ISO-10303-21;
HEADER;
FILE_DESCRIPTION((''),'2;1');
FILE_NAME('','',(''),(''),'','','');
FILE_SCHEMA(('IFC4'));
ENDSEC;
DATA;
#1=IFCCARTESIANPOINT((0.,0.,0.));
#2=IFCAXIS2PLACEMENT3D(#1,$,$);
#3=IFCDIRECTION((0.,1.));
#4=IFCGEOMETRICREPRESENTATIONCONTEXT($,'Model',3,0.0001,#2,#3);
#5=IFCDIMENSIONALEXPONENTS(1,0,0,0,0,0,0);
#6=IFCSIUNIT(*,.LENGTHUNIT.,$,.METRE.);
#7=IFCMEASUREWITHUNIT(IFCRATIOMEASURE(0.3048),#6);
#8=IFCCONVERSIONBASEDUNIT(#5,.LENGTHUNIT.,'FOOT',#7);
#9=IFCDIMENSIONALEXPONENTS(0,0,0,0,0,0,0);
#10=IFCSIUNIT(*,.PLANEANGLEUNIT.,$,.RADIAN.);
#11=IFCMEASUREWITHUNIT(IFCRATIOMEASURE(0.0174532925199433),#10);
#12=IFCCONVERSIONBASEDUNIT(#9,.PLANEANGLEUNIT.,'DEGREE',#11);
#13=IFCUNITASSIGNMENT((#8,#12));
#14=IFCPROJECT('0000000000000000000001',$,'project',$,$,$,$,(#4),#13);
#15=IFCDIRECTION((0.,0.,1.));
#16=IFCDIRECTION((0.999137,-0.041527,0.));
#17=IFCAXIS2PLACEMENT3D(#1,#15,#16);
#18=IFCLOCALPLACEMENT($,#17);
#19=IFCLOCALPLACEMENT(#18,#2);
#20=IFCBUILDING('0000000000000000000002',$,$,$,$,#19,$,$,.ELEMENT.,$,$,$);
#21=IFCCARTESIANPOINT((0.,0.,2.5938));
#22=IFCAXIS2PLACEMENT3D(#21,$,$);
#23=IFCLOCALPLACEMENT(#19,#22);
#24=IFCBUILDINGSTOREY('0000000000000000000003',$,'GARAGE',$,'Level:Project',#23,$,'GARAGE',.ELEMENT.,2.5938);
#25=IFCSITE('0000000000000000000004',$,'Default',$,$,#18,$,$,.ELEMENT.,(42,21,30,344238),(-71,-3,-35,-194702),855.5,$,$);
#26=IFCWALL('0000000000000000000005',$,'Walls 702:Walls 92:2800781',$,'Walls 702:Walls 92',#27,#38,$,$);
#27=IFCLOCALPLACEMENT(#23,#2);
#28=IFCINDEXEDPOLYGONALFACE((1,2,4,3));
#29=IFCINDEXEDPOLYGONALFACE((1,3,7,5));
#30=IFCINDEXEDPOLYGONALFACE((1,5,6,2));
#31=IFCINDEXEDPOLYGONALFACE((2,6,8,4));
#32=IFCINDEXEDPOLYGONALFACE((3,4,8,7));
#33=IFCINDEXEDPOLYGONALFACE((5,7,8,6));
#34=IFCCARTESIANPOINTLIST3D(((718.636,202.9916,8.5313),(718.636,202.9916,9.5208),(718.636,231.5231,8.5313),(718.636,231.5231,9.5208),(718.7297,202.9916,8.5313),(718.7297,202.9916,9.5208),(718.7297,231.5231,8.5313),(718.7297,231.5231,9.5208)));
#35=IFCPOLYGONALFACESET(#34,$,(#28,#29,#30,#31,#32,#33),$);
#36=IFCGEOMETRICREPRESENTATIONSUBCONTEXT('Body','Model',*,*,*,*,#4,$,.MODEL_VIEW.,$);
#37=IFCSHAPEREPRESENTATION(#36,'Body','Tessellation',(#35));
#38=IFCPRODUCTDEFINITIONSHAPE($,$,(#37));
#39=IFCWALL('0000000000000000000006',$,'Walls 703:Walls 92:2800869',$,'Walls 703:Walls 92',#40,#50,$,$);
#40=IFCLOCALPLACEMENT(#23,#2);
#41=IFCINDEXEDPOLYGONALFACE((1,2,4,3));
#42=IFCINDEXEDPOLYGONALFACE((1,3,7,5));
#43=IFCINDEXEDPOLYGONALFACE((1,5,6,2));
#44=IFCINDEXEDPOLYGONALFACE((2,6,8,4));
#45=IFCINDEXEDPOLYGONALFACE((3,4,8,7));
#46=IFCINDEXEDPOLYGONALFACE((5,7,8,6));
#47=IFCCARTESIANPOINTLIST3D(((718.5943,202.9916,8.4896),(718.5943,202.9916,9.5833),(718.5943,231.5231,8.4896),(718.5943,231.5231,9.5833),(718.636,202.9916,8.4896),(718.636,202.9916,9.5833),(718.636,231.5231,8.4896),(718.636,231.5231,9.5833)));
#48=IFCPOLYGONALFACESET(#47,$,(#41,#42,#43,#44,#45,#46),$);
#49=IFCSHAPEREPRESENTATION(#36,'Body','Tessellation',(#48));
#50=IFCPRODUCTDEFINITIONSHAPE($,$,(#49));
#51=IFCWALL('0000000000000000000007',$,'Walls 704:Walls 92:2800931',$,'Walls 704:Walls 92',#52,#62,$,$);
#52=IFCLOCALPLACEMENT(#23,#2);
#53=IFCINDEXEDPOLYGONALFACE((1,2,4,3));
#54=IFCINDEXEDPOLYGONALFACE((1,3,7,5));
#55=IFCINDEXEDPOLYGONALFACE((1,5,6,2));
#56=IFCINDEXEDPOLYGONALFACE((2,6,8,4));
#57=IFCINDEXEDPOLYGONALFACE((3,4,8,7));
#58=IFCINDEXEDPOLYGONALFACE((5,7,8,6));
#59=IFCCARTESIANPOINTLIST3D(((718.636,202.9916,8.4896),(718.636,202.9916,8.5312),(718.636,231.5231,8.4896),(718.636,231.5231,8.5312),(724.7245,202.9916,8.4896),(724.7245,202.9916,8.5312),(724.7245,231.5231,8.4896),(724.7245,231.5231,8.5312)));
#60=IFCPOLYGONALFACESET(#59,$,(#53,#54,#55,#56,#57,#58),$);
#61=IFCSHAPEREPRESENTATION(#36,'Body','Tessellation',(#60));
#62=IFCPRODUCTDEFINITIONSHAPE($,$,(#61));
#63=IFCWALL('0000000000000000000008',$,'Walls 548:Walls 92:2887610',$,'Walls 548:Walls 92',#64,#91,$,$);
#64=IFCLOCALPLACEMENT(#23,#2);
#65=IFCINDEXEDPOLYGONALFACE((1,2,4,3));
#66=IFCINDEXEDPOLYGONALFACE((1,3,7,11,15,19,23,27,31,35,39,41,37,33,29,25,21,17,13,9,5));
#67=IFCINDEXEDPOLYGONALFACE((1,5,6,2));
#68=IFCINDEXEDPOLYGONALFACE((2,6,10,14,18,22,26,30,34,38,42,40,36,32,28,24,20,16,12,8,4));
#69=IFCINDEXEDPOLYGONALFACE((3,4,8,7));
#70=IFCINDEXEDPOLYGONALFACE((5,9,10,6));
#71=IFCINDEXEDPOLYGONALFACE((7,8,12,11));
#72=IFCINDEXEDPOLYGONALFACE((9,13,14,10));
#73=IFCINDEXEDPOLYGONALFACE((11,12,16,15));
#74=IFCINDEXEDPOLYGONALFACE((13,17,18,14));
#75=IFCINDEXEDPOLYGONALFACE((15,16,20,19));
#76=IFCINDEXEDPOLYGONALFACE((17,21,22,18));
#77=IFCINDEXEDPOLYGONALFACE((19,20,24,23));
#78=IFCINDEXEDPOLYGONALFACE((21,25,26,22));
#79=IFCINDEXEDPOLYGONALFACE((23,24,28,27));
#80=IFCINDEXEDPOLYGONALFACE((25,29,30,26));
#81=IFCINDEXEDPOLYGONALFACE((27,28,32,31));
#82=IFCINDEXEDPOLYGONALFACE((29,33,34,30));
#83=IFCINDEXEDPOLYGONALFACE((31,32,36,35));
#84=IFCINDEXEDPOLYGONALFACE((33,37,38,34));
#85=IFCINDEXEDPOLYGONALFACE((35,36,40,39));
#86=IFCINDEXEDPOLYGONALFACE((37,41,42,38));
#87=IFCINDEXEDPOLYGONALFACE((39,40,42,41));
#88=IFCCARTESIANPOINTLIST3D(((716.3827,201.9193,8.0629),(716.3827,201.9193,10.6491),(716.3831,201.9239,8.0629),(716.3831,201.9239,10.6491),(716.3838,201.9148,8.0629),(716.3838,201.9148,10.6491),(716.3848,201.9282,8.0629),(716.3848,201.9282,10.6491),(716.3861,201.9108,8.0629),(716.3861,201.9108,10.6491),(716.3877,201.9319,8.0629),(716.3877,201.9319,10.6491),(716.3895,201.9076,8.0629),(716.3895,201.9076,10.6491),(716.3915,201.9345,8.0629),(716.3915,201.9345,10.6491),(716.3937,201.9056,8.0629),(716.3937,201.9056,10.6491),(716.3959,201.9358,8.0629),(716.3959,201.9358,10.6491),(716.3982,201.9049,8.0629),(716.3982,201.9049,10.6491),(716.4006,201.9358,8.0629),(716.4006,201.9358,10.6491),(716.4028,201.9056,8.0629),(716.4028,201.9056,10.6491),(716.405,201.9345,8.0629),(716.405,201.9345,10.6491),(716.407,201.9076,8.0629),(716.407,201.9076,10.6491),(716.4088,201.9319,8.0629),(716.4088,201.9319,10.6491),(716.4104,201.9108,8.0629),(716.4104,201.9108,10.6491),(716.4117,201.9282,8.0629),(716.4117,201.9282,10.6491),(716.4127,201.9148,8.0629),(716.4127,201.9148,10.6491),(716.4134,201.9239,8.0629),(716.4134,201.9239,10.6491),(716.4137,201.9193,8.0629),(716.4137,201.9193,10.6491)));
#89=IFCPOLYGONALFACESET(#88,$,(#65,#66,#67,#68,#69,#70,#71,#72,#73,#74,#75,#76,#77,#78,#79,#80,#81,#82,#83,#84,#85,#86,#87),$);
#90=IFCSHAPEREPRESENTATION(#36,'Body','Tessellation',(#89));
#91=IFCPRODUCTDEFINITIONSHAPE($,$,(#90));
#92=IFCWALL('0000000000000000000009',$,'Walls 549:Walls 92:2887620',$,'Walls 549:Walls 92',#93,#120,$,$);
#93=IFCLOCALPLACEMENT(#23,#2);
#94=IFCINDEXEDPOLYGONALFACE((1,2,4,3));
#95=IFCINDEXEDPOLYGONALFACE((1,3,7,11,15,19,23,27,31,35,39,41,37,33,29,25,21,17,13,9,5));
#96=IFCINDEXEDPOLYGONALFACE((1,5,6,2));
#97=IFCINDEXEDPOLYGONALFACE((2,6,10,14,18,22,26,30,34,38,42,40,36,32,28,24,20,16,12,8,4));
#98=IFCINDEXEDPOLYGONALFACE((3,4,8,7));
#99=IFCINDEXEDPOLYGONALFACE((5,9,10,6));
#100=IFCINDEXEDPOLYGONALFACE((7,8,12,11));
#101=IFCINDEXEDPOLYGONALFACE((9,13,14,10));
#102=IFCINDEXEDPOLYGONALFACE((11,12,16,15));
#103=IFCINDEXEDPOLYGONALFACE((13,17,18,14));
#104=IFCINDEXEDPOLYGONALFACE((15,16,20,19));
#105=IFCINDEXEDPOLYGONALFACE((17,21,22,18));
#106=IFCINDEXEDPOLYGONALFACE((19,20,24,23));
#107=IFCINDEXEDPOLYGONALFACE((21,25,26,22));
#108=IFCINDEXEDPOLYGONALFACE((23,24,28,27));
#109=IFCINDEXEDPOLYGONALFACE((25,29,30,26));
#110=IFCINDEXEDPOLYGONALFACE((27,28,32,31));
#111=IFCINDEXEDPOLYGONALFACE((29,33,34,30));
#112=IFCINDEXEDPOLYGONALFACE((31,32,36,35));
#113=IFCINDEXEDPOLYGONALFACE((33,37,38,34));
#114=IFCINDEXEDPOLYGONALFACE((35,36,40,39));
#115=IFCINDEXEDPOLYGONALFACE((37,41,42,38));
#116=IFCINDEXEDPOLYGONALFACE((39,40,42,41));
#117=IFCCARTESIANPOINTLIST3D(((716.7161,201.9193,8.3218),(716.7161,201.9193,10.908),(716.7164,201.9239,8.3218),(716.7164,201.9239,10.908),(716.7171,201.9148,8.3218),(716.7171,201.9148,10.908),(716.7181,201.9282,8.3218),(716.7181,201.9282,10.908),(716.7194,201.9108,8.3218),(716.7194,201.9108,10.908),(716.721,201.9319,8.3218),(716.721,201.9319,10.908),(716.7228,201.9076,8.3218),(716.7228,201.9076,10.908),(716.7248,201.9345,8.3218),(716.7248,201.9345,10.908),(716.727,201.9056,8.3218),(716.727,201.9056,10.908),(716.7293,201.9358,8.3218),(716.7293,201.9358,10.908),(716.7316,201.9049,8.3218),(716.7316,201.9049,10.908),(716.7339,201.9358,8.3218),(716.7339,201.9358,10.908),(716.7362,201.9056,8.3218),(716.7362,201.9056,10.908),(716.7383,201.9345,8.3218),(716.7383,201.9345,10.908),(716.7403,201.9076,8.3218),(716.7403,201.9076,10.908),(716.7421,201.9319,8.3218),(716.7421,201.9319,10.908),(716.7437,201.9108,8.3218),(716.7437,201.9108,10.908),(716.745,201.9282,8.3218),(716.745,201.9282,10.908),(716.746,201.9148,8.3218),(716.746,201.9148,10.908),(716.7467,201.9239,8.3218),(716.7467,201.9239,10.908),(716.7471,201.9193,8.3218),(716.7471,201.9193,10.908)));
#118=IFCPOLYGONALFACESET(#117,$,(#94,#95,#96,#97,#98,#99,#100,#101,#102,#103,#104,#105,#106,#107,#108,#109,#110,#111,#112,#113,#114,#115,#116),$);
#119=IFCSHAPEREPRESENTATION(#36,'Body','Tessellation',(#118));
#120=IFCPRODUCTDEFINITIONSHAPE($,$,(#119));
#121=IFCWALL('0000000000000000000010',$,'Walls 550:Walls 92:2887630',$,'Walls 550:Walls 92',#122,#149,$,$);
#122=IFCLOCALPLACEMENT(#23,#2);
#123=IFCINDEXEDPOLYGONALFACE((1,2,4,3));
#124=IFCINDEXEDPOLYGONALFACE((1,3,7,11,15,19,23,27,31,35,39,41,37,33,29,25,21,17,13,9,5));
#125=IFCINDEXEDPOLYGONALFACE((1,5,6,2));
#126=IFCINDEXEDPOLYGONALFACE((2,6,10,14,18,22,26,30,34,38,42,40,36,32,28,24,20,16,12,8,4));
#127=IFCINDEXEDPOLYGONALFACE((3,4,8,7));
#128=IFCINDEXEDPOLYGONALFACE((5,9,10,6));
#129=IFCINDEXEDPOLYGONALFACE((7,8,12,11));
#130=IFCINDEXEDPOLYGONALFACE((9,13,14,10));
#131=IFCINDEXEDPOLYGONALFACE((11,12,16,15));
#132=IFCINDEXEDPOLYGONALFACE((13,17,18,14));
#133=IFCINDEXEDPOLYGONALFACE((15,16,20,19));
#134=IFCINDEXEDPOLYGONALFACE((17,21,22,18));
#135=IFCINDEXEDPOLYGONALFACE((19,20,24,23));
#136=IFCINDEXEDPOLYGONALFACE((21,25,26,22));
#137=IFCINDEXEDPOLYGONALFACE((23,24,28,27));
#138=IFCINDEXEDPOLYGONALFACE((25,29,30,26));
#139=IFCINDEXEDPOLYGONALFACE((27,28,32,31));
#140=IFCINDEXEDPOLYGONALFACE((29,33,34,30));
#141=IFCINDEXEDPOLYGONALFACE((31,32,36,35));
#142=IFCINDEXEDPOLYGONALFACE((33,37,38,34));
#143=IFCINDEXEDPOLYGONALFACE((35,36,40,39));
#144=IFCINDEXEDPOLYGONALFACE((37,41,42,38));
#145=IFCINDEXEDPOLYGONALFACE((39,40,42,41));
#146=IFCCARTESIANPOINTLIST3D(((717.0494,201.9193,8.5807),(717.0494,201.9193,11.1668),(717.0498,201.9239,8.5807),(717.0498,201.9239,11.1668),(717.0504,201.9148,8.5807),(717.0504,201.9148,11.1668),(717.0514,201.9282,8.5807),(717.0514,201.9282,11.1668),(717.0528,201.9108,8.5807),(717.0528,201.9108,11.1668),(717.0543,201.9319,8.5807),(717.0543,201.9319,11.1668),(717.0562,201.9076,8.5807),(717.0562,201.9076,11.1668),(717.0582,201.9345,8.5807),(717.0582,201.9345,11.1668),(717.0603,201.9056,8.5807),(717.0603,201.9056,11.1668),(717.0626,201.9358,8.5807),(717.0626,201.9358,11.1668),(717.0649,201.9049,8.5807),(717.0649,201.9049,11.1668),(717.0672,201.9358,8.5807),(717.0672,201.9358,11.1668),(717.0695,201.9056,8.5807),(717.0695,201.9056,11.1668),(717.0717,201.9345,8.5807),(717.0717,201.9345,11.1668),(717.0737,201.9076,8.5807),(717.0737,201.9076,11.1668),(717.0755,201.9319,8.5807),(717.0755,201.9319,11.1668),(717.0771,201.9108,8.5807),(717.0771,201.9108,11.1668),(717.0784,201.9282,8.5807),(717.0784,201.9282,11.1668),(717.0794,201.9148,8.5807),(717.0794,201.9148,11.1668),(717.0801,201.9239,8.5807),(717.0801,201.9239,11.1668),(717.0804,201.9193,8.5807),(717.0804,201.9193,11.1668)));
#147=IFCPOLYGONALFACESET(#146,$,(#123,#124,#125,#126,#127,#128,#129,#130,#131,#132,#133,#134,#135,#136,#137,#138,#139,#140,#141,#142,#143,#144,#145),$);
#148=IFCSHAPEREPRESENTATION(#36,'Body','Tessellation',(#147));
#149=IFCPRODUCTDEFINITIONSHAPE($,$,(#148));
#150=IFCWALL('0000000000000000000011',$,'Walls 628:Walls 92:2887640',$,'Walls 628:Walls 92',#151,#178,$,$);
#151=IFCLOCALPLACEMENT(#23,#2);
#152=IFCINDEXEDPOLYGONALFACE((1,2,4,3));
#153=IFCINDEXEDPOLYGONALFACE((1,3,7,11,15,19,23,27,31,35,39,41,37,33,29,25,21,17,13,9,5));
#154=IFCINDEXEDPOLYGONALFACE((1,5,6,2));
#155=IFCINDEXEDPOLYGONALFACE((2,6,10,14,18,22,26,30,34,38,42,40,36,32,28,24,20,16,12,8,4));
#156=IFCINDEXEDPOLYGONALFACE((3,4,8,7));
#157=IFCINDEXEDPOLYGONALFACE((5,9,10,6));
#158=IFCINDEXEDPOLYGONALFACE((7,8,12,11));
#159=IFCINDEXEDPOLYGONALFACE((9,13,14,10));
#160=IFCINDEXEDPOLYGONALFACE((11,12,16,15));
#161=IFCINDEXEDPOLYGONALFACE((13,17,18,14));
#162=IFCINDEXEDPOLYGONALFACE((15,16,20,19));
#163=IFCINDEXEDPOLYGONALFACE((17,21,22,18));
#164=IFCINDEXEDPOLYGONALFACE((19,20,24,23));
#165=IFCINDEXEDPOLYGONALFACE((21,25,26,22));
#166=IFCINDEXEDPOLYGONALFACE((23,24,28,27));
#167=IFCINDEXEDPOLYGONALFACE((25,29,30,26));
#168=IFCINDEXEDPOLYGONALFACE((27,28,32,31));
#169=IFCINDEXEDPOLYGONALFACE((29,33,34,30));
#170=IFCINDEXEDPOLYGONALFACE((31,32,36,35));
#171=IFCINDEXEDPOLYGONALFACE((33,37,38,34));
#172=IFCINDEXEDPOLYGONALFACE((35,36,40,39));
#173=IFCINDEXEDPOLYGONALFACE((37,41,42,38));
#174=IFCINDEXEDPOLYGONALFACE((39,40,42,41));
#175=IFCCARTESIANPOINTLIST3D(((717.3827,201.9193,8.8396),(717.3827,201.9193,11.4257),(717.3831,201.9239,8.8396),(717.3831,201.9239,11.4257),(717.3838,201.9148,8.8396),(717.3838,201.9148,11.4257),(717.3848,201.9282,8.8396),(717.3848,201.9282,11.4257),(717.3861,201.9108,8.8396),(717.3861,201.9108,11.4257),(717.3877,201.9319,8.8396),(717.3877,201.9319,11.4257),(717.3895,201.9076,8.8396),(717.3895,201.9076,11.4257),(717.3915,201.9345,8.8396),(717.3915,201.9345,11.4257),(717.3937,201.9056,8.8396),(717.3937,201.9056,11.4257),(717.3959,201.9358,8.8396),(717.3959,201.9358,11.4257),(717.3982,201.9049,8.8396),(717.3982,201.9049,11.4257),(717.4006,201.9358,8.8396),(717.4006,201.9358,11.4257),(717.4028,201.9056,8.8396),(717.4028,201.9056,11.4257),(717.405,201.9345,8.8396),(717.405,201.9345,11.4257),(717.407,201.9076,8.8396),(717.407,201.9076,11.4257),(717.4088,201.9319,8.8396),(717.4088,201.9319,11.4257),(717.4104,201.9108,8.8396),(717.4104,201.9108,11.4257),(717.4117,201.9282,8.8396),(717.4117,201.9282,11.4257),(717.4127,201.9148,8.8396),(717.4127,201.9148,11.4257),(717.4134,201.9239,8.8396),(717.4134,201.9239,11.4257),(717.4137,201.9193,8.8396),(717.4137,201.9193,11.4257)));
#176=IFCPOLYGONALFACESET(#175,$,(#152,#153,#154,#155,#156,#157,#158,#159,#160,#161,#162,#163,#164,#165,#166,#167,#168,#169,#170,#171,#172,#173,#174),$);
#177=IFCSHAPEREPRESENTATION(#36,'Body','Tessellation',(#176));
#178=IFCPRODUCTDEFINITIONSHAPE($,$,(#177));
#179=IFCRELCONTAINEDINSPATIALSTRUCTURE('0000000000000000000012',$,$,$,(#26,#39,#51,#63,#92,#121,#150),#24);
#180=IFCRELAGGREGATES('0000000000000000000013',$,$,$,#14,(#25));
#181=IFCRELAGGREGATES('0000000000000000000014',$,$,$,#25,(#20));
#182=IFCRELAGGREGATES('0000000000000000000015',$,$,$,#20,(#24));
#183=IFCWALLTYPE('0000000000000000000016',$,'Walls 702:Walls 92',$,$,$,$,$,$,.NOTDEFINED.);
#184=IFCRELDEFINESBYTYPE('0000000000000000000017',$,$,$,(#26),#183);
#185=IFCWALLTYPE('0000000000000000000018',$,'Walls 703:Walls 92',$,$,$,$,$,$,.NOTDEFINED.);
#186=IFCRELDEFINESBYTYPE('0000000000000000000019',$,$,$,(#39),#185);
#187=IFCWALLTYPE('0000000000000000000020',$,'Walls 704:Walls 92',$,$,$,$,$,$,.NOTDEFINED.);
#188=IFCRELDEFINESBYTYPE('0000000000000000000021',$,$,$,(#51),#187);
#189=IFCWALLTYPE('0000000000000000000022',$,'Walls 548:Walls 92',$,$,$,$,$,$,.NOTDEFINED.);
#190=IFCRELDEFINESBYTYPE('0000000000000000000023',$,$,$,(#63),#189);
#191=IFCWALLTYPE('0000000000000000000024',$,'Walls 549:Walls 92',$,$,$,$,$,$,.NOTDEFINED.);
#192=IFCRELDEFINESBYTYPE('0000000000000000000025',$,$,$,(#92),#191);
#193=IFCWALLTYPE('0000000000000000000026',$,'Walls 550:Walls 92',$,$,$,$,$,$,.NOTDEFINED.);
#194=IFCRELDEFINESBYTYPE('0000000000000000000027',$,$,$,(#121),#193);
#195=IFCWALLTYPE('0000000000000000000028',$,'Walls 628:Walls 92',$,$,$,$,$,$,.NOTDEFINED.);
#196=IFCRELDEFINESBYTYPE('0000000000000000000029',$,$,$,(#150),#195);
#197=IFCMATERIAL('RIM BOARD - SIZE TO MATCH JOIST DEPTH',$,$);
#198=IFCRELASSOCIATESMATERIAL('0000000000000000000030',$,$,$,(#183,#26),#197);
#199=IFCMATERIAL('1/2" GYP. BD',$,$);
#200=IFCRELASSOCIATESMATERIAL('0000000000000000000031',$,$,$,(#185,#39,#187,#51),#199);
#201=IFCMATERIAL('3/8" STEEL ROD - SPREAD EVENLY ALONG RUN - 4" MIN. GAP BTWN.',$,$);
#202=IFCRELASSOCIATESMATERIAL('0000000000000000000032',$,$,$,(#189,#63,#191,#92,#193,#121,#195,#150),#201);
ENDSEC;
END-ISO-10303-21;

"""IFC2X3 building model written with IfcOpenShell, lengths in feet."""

from ifc_helpers import new_model, entity, si_unit, converted_unit, direction, frame, frame_2d, origin, origin_2d_with_axis, place, context, subcontext, project, spatial, rectangle, circle, extrude, material, type_object, element, save


model = new_model("IFC2X3")

# Units and contexts
model_context = context("Model", 3, precision=0.0001, world=origin(), true_north=direction((0.0, 1.0)))
body_context = subcontext(model_context, "Body", "Model", "MODEL_VIEW")
ifc_project = project(units=[converted_unit("LENGTHUNIT", "FOOT", entity("IfcRatioMeasure", 0.3048), si_unit("LENGTHUNIT", "METRE"), dimensions=[1, 0, 0, 0, 0, 0, 0]), converted_unit("PLANEANGLEUNIT", "DEGREE", entity("IfcRatioMeasure", 0.0174532925199433), si_unit("PLANEANGLEUNIT", "RADIAN"), dimensions=[0, 0, 0, 0, 0, 0, 0])], contexts=[model_context])

# Site, building, storey
site_placement = place(None, frame((0.0, 0.0, 0.0), z_axis=(0.0, 0.0, 1.0), x_axis=(0.999137, -0.041527, 0.0)))
site = spatial("IfcSite", under=ifc_project, at=site_placement, Name="Default", CompositionType="ELEMENT", RefLatitude=(42, 21, 30, 344238), RefLongitude=(-71, -3, -35, -194702), RefElevation=855.5)
building_placement = place(site_placement, origin())
building = spatial("IfcBuilding", under=site, at=building_placement, CompositionType="ELEMENT")
storey_placement = place(building_placement, frame((0.0, 0.0, 2.5938)))
storey = spatial("IfcBuildingStorey", under=building, at=storey_placement, Name="GARAGE", ObjectType="Level:Project", LongName="GARAGE", CompositionType="ELEMENT", Elevation=2.5938)

# Walls
ifc_material_1 = material(Name="3/8\" STEEL ROD - SPREAD EVENLY ALONG RUN - 4\" MIN. GAP BTWN.")
ifc_material_2 = material(Name="RIM BOARD - SIZE TO MATCH JOIST DEPTH")
wall_type_1 = type_object("IfcWallType", Name="Walls 702:Walls 92", PredefinedType="NOTDEFINED", material=ifc_material_2)
wall_1_placement = place(storey_placement, frame((718.636, 202.9916, 8.5313), z_axis=(0.0, 0.0, 1.0), x_axis=(0.0, 1.0, 0.0)))
element("IfcWall", 1, at=wall_1_placement, inside=storey, type_object=wall_type_1, material=ifc_material_2, Name="Walls 702:Walls 92:2800781", ObjectType="Walls 702:Walls 92", context=body_context, shape_type="SweptSolid", body=[
    extrude(rectangle(XDim=28.5315, YDim=0.0938, at=frame_2d((0.0, 0.0), x_axis=(1.0, 0.0))), frame((14.2657, -0.0469, 0.0)), (0.0, 0.0, 1.0), 0.9896),
])
ifc_material_3 = material(Name="1/2\" GYP. BD")
wall_type_2 = type_object("IfcWallType", Name="Walls 703:Walls 92", PredefinedType="NOTDEFINED", material=ifc_material_3)
wall_2_placement = place(storey_placement, frame((718.5943, 202.9916, 8.4896), z_axis=(0.0, 0.0, 1.0), x_axis=(0.0, 1.0, 0.0)))
element("IfcWall", 2, at=wall_2_placement, inside=storey, type_object=wall_type_2, material=ifc_material_3, Name="Walls 703:Walls 92:2800869", ObjectType="Walls 703:Walls 92", context=body_context, shape_type="SweptSolid", body=[
    extrude(rectangle(XDim=28.5315, YDim=0.0417, at=frame_2d((0.0, 0.0), x_axis=(1.0, 0.0))), frame((14.2657, -0.0208, 0.0)), (0.0, 0.0, 1.0), 1.0937),
])
wall_type_3 = type_object("IfcWallType", Name="Walls 704:Walls 92", PredefinedType="NOTDEFINED", material=ifc_material_3)
wall_3_placement = place(storey_placement, frame((718.636, 202.9916, 8.4896), z_axis=(0.0, 0.0, 1.0), x_axis=(0.0, 1.0, 0.0)))
element("IfcWall", 3, at=wall_3_placement, inside=storey, type_object=wall_type_3, material=ifc_material_3, Name="Walls 704:Walls 92:2800931", ObjectType="Walls 704:Walls 92", context=body_context, shape_type="SweptSolid", body=[
    extrude(rectangle(XDim=28.5315, YDim=6.0885, at=frame_2d((0.0, 0.0), x_axis=(1.0, 0.0))), frame((14.2657, -3.0443, 0.0)), (0.0, 0.0, 1.0), 0.0417),
])
wall_type_4 = type_object("IfcWallType", Name="Walls 548:Walls 92", PredefinedType="NOTDEFINED", material=ifc_material_1)
wall_4_placement = place(storey_placement, frame((716.3827, 201.9049, 8.0629)))
element("IfcWall", 4, at=wall_4_placement, inside=storey, type_object=wall_type_4, material=ifc_material_1, Name="Walls 548:Walls 92:2887610", ObjectType="Walls 548:Walls 92", context=body_context, shape_type="SweptSolid", body=[
    extrude(circle(Radius=0.0155, at=origin_2d_with_axis()), frame((0.0155, 0.0155, 0.0), z_axis=(0.0, 0.0, 1.0), x_axis=(0.0, -1.0, 0.0)), (0.0, 0.0, 1.0), 2.5862),
])
wall_type_5 = type_object("IfcWallType", Name="Walls 549:Walls 92", PredefinedType="NOTDEFINED", material=ifc_material_1)
wall_5_placement = place(storey_placement, frame((716.716, 201.9049, 8.3218)))
element("IfcWall", 5, at=wall_5_placement, inside=storey, type_object=wall_type_5, material=ifc_material_1, Name="Walls 549:Walls 92:2887620", ObjectType="Walls 549:Walls 92", context=body_context, shape_type="SweptSolid", body=[
    extrude(circle(Radius=0.0155, at=origin_2d_with_axis()), frame((0.0155, 0.0155, 0.0), z_axis=(0.0, 0.0, 1.0), x_axis=(0.0, -1.0, 0.0)), (0.0, 0.0, 1.0), 2.5862),
])
wall_type_6 = type_object("IfcWallType", Name="Walls 550:Walls 92", PredefinedType="NOTDEFINED", material=ifc_material_1)
wall_6_placement = place(storey_placement, frame((717.0494, 201.9049, 8.5807)))
element("IfcWall", 6, at=wall_6_placement, inside=storey, type_object=wall_type_6, material=ifc_material_1, Name="Walls 550:Walls 92:2887630", ObjectType="Walls 550:Walls 92", context=body_context, shape_type="SweptSolid", body=[
    extrude(circle(Radius=0.0155, at=origin_2d_with_axis()), frame((0.0155, 0.0155, 0.0), z_axis=(0.0, 0.0, 1.0), x_axis=(0.0, -1.0, 0.0)), (0.0, 0.0, 1.0), 2.5862),
])
wall_type_7 = type_object("IfcWallType", Name="Walls 628:Walls 92", PredefinedType="NOTDEFINED", material=ifc_material_1)
wall_7_placement = place(storey_placement, frame((717.3827, 201.9049, 8.8396)))
element("IfcWall", 7, at=wall_7_placement, inside=storey, type_object=wall_type_7, material=ifc_material_1, Name="Walls 628:Walls 92:2887640", ObjectType="Walls 628:Walls 92", context=body_context, shape_type="SweptSolid", body=[
    extrude(circle(Radius=0.0155, at=origin_2d_with_axis()), frame((0.0155, 0.0155, 0.0), z_axis=(0.0, 0.0, 1.0), x_axis=(0.0, -1.0, 0.0)), (0.0, 0.0, 1.0), 2.5862),
])

save(model, "model.ifc")
